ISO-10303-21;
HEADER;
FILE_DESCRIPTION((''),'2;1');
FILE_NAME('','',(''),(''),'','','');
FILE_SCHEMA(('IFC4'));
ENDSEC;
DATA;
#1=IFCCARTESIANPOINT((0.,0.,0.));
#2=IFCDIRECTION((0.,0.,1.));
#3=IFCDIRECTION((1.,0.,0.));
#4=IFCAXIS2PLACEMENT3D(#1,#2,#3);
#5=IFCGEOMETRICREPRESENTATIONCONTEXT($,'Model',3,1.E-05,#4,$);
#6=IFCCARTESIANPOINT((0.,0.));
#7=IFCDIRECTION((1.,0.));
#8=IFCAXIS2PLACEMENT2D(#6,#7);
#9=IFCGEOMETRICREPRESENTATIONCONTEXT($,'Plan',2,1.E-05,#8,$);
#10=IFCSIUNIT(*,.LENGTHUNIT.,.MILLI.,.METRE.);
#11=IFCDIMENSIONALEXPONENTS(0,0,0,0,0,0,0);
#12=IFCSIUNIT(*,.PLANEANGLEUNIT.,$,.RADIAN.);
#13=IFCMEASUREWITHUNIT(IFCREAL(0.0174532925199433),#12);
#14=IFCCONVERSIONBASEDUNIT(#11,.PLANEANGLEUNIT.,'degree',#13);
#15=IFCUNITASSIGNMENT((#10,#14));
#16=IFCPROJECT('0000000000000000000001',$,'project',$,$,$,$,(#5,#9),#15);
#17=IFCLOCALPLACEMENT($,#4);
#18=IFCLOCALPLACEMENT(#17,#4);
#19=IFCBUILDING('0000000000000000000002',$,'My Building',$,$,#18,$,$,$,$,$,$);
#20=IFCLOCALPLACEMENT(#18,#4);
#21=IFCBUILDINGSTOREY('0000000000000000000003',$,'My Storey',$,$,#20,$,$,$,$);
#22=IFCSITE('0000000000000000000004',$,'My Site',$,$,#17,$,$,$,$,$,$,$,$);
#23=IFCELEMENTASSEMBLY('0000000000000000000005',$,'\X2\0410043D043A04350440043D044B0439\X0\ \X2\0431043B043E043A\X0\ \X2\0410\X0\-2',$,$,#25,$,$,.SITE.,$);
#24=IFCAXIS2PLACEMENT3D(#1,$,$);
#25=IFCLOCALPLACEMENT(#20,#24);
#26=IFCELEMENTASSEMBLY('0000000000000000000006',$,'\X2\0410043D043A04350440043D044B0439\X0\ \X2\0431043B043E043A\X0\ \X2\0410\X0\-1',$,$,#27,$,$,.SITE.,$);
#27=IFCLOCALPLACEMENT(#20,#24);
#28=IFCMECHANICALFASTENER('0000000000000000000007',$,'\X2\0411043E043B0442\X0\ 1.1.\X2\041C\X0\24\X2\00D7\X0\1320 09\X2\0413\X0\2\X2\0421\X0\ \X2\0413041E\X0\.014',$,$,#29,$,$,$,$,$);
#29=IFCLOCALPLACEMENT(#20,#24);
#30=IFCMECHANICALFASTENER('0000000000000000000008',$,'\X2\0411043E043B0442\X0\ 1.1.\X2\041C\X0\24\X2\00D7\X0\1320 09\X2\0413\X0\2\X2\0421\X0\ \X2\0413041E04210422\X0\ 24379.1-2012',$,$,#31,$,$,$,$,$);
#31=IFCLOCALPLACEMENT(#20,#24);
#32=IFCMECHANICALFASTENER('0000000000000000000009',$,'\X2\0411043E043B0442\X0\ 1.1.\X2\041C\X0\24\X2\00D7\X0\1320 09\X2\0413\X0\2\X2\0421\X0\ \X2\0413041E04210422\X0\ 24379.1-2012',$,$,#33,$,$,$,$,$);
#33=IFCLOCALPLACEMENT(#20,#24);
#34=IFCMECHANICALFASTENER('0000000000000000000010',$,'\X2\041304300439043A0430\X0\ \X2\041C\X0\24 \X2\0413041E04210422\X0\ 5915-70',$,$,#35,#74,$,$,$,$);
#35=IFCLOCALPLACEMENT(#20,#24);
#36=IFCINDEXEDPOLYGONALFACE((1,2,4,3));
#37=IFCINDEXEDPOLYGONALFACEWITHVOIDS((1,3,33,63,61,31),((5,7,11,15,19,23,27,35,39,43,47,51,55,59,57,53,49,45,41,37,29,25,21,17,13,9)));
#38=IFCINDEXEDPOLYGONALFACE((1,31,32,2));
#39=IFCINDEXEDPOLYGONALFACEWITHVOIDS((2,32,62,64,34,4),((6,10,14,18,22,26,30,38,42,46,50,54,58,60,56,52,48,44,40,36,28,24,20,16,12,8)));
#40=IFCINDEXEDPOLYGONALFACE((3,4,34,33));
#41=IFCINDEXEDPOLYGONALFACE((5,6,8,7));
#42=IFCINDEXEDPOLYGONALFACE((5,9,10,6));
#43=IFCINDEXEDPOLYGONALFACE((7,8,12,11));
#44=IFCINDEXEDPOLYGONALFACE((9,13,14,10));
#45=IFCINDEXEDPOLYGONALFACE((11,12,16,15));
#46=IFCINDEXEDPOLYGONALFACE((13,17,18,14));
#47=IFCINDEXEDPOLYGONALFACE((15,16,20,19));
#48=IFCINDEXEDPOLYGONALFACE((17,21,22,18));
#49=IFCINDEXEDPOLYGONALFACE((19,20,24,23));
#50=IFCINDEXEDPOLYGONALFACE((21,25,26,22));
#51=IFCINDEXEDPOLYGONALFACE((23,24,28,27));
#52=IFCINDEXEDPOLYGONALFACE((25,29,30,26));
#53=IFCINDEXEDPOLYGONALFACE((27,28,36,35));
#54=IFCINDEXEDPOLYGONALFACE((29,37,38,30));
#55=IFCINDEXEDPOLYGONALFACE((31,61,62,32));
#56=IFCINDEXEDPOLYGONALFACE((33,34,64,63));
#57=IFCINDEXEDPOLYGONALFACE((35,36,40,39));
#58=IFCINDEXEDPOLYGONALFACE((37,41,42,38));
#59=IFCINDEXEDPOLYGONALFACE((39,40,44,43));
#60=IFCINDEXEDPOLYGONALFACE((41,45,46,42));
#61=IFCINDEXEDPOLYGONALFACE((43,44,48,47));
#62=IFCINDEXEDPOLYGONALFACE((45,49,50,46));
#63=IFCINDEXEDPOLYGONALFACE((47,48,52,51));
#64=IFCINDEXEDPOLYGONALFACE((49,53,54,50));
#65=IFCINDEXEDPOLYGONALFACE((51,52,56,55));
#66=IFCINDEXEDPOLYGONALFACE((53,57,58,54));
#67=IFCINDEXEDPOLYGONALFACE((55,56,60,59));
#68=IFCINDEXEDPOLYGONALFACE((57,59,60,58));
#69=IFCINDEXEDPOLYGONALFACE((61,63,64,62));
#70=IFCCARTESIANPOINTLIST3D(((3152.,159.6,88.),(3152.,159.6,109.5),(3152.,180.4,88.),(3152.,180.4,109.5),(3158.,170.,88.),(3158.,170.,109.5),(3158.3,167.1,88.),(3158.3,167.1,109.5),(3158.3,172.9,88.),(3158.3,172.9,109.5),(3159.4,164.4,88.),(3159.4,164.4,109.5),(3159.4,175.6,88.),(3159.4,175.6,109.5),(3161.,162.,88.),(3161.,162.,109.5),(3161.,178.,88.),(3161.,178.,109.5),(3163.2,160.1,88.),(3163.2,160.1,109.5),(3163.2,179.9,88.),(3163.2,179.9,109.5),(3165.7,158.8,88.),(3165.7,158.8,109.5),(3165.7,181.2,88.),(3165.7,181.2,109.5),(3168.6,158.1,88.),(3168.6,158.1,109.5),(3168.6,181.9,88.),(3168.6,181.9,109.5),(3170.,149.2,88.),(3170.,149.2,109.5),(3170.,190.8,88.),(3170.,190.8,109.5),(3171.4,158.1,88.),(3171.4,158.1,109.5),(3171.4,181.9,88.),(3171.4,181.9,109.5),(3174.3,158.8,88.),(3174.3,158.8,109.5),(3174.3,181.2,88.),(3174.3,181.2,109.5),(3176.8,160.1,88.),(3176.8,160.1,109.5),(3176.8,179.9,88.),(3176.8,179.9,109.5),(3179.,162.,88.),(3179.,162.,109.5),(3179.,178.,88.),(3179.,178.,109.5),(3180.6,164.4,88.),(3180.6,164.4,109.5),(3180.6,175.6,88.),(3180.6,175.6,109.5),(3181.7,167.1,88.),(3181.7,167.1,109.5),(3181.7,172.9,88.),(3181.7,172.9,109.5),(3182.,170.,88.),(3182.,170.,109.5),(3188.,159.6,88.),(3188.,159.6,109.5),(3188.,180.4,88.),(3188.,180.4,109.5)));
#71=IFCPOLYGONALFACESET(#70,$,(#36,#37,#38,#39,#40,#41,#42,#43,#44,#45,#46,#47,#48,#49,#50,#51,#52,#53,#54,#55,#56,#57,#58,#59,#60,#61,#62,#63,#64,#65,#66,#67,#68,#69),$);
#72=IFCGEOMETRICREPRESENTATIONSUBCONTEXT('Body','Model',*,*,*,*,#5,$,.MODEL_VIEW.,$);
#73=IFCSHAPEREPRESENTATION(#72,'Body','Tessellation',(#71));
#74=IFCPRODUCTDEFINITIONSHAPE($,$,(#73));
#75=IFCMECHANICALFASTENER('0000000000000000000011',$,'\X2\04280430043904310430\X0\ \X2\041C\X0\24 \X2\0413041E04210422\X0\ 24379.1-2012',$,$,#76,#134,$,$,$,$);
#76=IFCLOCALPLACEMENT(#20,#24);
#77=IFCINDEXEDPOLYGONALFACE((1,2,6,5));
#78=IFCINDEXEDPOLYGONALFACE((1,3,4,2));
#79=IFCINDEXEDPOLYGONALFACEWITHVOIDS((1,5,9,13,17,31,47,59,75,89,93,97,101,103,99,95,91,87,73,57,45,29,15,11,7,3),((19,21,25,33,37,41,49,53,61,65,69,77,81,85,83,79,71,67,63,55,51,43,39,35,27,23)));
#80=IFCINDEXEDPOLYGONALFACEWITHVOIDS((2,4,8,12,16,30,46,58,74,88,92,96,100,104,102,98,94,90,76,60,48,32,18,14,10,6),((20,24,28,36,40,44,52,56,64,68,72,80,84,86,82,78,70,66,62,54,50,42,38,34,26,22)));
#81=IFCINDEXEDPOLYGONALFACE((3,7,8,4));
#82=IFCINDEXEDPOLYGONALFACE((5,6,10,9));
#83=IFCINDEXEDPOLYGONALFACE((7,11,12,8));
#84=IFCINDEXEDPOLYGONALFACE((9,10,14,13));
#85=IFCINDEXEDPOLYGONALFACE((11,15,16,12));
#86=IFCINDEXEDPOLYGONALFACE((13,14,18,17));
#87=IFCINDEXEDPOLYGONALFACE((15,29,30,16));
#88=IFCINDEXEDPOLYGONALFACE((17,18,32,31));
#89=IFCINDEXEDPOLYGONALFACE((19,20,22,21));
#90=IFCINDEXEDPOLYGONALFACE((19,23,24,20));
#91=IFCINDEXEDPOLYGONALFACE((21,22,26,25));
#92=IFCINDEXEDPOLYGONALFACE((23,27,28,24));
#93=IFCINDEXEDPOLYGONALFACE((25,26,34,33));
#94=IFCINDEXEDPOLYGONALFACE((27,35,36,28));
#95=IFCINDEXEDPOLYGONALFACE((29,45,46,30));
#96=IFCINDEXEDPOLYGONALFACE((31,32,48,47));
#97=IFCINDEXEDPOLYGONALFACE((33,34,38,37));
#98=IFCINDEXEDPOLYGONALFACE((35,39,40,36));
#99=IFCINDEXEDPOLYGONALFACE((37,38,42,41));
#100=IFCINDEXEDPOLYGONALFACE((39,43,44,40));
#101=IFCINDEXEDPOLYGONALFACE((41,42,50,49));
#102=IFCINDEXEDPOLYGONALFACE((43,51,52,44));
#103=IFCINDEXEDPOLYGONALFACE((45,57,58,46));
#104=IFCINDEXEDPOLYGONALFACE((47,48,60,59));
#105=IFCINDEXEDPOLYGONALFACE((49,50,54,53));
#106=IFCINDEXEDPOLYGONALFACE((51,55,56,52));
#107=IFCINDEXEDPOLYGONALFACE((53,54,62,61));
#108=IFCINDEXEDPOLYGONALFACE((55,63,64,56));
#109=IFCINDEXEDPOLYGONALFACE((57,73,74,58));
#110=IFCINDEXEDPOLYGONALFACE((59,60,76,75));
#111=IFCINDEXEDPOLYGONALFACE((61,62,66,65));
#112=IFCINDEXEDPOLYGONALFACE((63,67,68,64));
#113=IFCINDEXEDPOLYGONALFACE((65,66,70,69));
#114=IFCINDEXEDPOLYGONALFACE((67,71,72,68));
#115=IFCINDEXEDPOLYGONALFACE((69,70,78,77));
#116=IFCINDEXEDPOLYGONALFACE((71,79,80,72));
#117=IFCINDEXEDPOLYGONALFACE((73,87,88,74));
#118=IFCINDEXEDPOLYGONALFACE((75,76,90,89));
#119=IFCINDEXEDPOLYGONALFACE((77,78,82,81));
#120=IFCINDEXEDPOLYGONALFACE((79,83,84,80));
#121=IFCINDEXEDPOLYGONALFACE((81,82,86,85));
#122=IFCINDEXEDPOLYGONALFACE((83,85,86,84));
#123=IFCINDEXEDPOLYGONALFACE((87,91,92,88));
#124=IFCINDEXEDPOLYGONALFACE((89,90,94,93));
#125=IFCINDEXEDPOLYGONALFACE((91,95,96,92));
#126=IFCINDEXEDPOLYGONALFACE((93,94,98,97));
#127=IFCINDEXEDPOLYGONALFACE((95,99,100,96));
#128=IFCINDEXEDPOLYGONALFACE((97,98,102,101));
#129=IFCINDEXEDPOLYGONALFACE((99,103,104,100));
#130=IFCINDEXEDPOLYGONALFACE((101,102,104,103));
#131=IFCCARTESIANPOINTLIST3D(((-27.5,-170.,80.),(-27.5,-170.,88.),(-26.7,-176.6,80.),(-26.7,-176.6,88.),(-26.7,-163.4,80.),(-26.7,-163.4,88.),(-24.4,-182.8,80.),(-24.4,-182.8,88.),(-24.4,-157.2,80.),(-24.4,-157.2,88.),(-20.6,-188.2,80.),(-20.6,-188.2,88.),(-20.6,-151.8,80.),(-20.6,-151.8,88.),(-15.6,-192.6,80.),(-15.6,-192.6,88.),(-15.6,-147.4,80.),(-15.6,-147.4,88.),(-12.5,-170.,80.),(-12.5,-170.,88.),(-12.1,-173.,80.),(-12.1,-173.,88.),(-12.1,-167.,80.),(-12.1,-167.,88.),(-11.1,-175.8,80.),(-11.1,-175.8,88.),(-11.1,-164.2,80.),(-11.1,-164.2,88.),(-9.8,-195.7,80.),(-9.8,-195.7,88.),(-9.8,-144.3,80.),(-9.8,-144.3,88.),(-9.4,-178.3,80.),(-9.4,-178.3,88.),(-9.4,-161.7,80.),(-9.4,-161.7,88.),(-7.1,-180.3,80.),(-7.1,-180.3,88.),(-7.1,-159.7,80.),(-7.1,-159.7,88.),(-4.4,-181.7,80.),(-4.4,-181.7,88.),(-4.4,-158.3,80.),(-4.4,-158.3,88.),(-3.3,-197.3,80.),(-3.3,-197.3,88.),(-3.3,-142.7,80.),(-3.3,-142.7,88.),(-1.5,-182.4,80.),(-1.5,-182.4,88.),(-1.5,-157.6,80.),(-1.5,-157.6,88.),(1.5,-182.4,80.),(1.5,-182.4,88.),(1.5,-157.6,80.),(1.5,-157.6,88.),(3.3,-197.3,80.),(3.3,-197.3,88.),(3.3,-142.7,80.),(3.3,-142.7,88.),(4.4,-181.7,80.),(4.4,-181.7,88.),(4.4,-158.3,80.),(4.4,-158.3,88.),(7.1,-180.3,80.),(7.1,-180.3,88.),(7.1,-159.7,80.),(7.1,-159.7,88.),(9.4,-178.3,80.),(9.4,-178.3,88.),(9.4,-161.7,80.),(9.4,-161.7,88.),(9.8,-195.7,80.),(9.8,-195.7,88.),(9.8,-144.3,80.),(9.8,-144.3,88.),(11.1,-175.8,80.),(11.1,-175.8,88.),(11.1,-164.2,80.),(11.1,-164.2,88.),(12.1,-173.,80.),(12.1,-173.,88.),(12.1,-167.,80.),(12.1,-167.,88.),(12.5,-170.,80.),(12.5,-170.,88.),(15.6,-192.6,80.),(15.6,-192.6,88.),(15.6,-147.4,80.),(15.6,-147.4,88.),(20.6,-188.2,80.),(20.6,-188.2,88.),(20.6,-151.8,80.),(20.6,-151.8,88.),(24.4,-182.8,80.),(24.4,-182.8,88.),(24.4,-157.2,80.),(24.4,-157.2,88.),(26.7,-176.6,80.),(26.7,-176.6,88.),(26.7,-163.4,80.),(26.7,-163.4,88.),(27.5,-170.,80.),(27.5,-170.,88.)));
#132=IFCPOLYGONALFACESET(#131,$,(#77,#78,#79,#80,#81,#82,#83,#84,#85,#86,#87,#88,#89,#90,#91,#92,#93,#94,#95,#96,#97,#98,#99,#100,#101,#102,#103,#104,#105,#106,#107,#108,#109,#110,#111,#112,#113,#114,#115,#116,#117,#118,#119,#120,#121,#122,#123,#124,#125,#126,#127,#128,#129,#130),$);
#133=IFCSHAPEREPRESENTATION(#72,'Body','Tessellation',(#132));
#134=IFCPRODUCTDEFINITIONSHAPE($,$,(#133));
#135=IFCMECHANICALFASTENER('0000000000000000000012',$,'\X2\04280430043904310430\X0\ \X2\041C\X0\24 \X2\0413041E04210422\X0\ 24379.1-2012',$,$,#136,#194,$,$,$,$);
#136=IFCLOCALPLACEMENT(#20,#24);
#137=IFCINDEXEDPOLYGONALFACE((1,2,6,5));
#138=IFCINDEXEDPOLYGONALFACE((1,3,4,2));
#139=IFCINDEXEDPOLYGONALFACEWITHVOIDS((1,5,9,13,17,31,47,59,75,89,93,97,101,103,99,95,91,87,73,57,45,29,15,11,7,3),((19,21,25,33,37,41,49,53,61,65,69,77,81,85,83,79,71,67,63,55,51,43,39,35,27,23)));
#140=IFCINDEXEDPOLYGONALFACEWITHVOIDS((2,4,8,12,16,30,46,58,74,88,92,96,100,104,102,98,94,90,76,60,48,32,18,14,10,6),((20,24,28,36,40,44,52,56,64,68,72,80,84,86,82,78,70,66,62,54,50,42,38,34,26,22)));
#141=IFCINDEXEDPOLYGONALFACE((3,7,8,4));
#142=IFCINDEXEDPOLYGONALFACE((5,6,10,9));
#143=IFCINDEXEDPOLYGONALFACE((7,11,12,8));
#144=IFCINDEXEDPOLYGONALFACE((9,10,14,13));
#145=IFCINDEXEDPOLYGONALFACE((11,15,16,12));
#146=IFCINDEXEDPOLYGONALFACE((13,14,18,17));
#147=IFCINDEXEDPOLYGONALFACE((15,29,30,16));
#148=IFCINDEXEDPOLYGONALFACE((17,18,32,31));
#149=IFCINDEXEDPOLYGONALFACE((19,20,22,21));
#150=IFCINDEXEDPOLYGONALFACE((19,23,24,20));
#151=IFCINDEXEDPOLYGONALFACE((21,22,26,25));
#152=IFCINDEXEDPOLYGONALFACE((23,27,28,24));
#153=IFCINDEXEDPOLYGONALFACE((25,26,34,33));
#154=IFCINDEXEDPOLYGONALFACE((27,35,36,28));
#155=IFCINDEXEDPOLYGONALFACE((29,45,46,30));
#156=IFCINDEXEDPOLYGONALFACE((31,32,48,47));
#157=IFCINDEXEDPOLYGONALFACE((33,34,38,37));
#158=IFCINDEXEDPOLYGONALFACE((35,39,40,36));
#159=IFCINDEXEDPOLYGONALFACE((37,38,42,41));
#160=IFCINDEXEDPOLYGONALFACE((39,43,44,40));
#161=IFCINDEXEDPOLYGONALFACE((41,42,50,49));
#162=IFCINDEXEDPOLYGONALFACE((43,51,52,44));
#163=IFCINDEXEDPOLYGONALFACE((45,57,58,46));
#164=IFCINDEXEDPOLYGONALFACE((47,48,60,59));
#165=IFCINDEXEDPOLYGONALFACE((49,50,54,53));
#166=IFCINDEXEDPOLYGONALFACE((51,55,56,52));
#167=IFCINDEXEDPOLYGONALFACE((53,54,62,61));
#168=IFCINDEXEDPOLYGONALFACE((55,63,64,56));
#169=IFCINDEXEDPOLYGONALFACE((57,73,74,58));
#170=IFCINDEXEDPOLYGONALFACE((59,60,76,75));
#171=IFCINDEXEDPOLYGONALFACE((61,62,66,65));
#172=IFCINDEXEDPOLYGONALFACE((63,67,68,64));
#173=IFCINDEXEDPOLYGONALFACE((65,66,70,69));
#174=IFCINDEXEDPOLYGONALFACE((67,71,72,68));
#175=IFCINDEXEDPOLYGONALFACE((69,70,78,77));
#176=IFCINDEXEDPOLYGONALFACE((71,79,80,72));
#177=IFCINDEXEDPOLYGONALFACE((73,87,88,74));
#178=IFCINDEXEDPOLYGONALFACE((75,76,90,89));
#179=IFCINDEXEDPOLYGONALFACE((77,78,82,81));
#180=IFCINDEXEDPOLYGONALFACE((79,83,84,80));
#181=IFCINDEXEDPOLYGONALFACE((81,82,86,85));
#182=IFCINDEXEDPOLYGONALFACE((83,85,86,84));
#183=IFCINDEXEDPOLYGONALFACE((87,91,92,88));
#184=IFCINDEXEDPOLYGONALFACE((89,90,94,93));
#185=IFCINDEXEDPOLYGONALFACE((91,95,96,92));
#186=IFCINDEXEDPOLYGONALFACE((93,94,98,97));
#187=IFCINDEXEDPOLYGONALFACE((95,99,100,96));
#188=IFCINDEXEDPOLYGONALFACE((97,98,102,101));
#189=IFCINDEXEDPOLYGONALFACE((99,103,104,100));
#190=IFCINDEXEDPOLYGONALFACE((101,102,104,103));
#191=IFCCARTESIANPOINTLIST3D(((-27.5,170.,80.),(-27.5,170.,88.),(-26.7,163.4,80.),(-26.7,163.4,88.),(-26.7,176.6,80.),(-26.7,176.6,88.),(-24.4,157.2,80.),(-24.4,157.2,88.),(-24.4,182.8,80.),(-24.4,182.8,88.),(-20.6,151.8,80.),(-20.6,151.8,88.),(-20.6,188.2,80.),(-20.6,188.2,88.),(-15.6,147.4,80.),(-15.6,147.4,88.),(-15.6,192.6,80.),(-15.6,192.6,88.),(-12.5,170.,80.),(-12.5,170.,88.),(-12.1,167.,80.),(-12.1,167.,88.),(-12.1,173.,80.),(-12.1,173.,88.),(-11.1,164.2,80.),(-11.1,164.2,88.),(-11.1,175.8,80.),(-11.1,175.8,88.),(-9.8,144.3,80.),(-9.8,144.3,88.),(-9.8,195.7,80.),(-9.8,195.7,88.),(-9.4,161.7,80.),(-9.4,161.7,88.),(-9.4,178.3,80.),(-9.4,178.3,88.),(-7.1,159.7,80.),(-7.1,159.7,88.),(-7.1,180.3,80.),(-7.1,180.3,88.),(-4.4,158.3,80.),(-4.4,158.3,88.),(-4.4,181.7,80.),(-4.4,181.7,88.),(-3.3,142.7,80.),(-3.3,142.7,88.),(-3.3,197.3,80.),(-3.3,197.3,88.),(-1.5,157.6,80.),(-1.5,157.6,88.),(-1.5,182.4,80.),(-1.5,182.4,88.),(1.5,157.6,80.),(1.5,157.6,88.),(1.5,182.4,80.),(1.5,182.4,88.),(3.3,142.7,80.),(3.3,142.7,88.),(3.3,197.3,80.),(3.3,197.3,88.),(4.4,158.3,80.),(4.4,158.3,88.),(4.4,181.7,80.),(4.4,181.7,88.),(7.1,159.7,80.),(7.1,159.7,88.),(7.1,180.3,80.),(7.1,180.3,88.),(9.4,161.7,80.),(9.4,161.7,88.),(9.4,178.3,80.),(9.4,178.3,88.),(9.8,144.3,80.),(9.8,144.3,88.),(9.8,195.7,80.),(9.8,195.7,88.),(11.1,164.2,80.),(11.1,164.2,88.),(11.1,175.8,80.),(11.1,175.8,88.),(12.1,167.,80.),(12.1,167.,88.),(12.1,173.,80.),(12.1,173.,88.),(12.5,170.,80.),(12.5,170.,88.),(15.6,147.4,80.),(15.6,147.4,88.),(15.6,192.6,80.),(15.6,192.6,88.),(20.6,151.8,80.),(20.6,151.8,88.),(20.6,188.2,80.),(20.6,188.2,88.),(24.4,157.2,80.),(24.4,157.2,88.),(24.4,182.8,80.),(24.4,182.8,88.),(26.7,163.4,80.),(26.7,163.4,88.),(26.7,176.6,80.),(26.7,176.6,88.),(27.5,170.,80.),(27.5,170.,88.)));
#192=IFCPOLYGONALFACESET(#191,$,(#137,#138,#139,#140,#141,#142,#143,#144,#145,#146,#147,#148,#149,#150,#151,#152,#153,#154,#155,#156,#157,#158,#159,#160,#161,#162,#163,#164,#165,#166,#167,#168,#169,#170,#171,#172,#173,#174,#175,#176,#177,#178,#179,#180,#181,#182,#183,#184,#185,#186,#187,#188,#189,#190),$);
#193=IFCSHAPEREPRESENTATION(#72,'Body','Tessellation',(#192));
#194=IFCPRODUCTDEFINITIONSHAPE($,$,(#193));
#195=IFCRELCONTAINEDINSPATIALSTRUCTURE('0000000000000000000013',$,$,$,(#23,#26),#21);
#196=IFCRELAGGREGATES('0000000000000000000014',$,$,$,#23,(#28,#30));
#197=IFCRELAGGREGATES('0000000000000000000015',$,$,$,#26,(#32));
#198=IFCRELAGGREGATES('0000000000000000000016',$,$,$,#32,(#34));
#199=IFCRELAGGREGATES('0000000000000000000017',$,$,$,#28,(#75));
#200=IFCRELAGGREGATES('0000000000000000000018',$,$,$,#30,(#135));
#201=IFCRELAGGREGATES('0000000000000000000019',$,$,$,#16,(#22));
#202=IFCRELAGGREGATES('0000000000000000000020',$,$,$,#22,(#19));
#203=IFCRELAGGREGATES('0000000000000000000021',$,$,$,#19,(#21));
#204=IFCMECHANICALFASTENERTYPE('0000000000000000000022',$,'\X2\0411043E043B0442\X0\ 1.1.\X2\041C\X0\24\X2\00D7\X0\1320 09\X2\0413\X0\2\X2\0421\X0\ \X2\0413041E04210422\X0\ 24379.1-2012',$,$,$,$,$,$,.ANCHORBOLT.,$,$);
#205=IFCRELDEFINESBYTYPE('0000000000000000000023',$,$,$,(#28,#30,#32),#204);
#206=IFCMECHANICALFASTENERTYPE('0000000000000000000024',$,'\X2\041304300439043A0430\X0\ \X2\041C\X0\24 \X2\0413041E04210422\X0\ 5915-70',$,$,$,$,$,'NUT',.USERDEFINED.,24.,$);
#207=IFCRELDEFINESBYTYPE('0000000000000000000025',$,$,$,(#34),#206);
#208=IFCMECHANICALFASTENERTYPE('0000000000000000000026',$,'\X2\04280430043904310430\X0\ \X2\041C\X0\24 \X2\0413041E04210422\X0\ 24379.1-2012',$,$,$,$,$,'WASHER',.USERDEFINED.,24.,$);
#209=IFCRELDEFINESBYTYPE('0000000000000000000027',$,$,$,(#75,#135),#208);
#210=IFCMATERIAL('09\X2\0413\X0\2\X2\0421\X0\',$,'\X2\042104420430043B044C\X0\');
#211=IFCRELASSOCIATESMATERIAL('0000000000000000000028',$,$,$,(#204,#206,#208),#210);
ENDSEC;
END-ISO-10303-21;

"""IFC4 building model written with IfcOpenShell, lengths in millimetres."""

from ifc_helpers import new_model, entity, si_unit, converted_unit, frame, origin_with_axes, origin_2d_with_axis, place, context, subcontext, project, spatial, polyline, outline, extrude, source, transform, mapped, material, type_object, type_shapes, element, aggregate, save


model = new_model("IFC4")

# Units and contexts
model_context = context("Model", 3, precision=1e-05, world=origin_with_axes())
plan_context = context("Plan", 2, precision=1e-05, world=origin_2d_with_axis())
body_context = subcontext(model_context, "Body", "Model", "MODEL_VIEW")
ifc_project = project(units=[si_unit("LENGTHUNIT", "METRE", prefix="MILLI"), converted_unit("PLANEANGLEUNIT", "degree", entity("IfcReal", 0.0174532925199433), si_unit("PLANEANGLEUNIT", "RADIAN"), dimensions=[0, 0, 0, 0, 0, 0, 0])], contexts=[model_context, plan_context])

# Site, building, storey
site_placement = place(None, origin_with_axes())
site = spatial("IfcSite", under=ifc_project, at=site_placement, Name="My Site")
building_placement = place(site_placement, origin_with_axes())
building = spatial("IfcBuilding", under=site, at=building_placement, Name="My Building")
storey_placement = place(building_placement, origin_with_axes())
storey = spatial("IfcBuildingStorey", under=building, at=storey_placement, Name="My Storey")

# Element assemblies
placement_1 = place(storey_placement, origin_with_axes())
assembly_1 = element("IfcElementAssembly", 1, at=placement_1, inside=storey, Name="Анкерный блок А-2", AssemblyPlace="SITE")
placement_2 = place(storey_placement, frame((3000.0, 0.0, 0.0), z_axis=(0.0, 0.0, 1.0), x_axis=(1.0, 0.0, 0.0)))
assembly_2 = element("IfcElementAssembly", 2, at=placement_2, inside=storey, Name="Анкерный блок А-1", AssemblyPlace="SITE")

# Mechanical fastener
ifc_material_1 = material(Name="09Г2С", Category="Сталь")
mechanical_fastener_type_1 = type_object("IfcMechanicalFastenerType", Name="Болт 1.1.М24×1320 09Г2С ГОСТ 24379.1-2012", PredefinedType="ANCHORBOLT", material=ifc_material_1)
mechanical_fastener_1_placement = place(placement_1, frame((0.0, -170.0, 0.0), z_axis=(0.0, 0.0, 1.0), x_axis=(1.0, 0.0, 0.0)))
mechanical_fastener_1 = element("IfcMechanicalFastener", 3, at=mechanical_fastener_1_placement, type_object=mechanical_fastener_type_1, Name="Болт 1.1.М24×1320 09Г2С ГО.014")

# Mechanical fastener
mechanical_fastener_2_placement = place(placement_1, frame((0.0, 170.0, 0.0), z_axis=(0.0, 0.0, 1.0), x_axis=(-1.0, 0.0, 0.0)))
mechanical_fastener_2 = element("IfcMechanicalFastener", 4, at=mechanical_fastener_2_placement, type_object=mechanical_fastener_type_1, Name="Болт 1.1.М24×1320 09Г2С ГОСТ 24379.1-2012")
aggregate(assembly_1, [mechanical_fastener_1, mechanical_fastener_2])

# Mechanical fasteners
mechanical_fastener_3_placement = place(placement_2, frame((170.0, 170.0, 0.0), z_axis=(0.0, 0.0, 1.0), x_axis=(-1.0, 0.0, 0.0)))
mechanical_fastener_3 = element("IfcMechanicalFastener", 5, at=mechanical_fastener_3_placement, type_object=mechanical_fastener_type_1, Name="Болт 1.1.М24×1320 09Г2С ГОСТ 24379.1-2012")
aggregate(assembly_2, [mechanical_fastener_3])
mechanical_fastener_type_2 = type_object("IfcMechanicalFastenerType", Name="Гайка М24 ГОСТ 5915-70", ElementType="NUT", NominalDiameter=24.0, PredefinedType="USERDEFINED", material=ifc_material_1)
shared_shape_1 = source(origin_with_axes(), body_context, "Body", "SweptSolid", [
    extrude(outline(polyline([(-10.4, -18.0), (10.4, -18.0), (20.8, 0.0), (10.4, 18.0), (-10.4, 18.0), (-20.8, 0.0), (-10.4, -18.0)]), holes=[polyline([(-8.0, 9.0), (-5.6, 10.6), (-2.9, 11.7), (0.0, 12.0), (2.9, 11.7), (5.6, 10.6), (8.0, 9.0), (9.9, 6.8), (11.2, 4.3), (11.9, 1.4), (11.9, -1.4), (11.2, -4.3), (9.9, -6.8), (8.0, -9.0), (5.6, -10.6), (2.9, -11.7), (0.0, -12.0), (-2.9, -11.7), (-5.6, -10.6), (-8.0, -9.0), (-9.9, -6.8), (-11.2, -4.3), (-11.9, -1.4), (-11.9, 1.4), (-11.2, 4.3), (-9.9, 6.8), (-8.0, 9.0)])]), frame((0.0, 0.0, 0.0), z_axis=(0.0, 0.0, 1.0), x_axis=(0.0, 1.0, 0.0)), (0.0, 0.0, 1.0), 21.5),
])
type_shapes(mechanical_fastener_type_2, [shared_shape_1])
mechanical_fastener_4_placement = place(mechanical_fastener_3_placement, frame((0.0, 0.0, 88.0), z_axis=(0.0, 0.0, 1.0), x_axis=(1.0, 0.0, 0.0)))
mechanical_fastener_4 = element("IfcMechanicalFastener", 6, at=mechanical_fastener_4_placement, type_object=mechanical_fastener_type_2, Name="Гайка М24 ГОСТ 5915-70", context=body_context, shape_type="MappedRepresentation", body=[
    mapped(shared_shape_1, transform((0.0, 0.0, 0.0), x_axis=(1.0, 0.0, 0.0), y_axis=(0.0, 1.0, 0.0), z_axis=(0.0, 0.0, 1.0), scale=1.0)),
])
aggregate(mechanical_fastener_3, [mechanical_fastener_4])
mechanical_fastener_type_3 = type_object("IfcMechanicalFastenerType", Name="Шайба М24 ГОСТ 24379.1-2012", ElementType="WASHER", NominalDiameter=24.0, PredefinedType="USERDEFINED", material=ifc_material_1)
shared_shape_2 = source(origin_with_axes(), body_context, "Body", "SweptSolid", [
    extrude(outline(polyline([(27.5, 0.0), (26.7, 6.6), (24.4, 12.8), (20.6, 18.2), (15.6, 22.6), (9.8, 25.7), (3.3, 27.3), (-3.3, 27.3), (-9.8, 25.7), (-15.6, 22.6), (-20.6, 18.2), (-24.4, 12.8), (-26.7, 6.6), (-27.5, 0.0), (-26.7, -6.6), (-24.4, -12.8), (-20.6, -18.2), (-15.6, -22.6), (-9.8, -25.7), (-3.3, -27.3), (3.3, -27.3), (9.8, -25.7), (15.6, -22.6), (20.6, -18.2), (24.4, -12.8), (26.7, -6.6), (27.5, 0.0)]), holes=[polyline([(-4.4, -11.7), (-7.1, -10.3), (-9.4, -8.3), (-11.1, -5.8), (-12.1, -3.0), (-12.5, 0.0), (-12.1, 3.0), (-11.1, 5.8), (-9.4, 8.3), (-7.1, 10.3), (-4.4, 11.7), (-1.5, 12.4), (1.5, 12.4), (4.4, 11.7), (7.1, 10.3), (9.4, 8.3), (11.1, 5.8), (12.1, 3.0), (12.5, 0.0), (12.1, -3.0), (11.1, -5.8), (9.4, -8.3), (7.1, -10.3), (4.4, -11.7), (1.5, -12.4), (-1.5, -12.4), (-4.4, -11.7)])]), frame((0.0, 0.0, 0.0), z_axis=(0.0, 0.0, 1.0), x_axis=(0.120537, -0.992709, 0.0)), (0.0, 0.0, 1.0), 8.0),
])
type_shapes(mechanical_fastener_type_3, [shared_shape_2])
mechanical_fastener_5_placement = place(mechanical_fastener_1_placement, frame((0.0, 0.0, 80.0), z_axis=(0.0, 0.0, 1.0), x_axis=(1.0, 0.0, 0.0)))
mechanical_fastener_5 = element("IfcMechanicalFastener", 7, at=mechanical_fastener_5_placement, type_object=mechanical_fastener_type_3, Name="Шайба М24 ГОСТ 24379.1-2012", context=body_context, shape_type="MappedRepresentation", body=[
    mapped(shared_shape_2, transform((0.0, 0.0, 0.0), x_axis=(1.0, 0.0, 0.0), y_axis=(0.0, 1.0, 0.0), z_axis=(0.0, 0.0, 1.0), scale=1.0)),
])
aggregate(mechanical_fastener_1, [mechanical_fastener_5])
mechanical_fastener_6_placement = place(mechanical_fastener_2_placement, frame((0.0, 0.0, 80.0), z_axis=(0.0, 0.0, 1.0), x_axis=(1.0, 0.0, 0.0)))
mechanical_fastener_6 = element("IfcMechanicalFastener", 8, at=mechanical_fastener_6_placement, type_object=mechanical_fastener_type_3, Name="Шайба М24 ГОСТ 24379.1-2012", context=body_context, shape_type="MappedRepresentation", body=[
    mapped(shared_shape_2, transform((0.0, 0.0, 0.0), x_axis=(1.0, 0.0, 0.0), y_axis=(0.0, 1.0, 0.0), z_axis=(0.0, 0.0, 1.0), scale=1.0)),
])
aggregate(mechanical_fastener_2, [mechanical_fastener_6])

save(model, "model.ifc")
